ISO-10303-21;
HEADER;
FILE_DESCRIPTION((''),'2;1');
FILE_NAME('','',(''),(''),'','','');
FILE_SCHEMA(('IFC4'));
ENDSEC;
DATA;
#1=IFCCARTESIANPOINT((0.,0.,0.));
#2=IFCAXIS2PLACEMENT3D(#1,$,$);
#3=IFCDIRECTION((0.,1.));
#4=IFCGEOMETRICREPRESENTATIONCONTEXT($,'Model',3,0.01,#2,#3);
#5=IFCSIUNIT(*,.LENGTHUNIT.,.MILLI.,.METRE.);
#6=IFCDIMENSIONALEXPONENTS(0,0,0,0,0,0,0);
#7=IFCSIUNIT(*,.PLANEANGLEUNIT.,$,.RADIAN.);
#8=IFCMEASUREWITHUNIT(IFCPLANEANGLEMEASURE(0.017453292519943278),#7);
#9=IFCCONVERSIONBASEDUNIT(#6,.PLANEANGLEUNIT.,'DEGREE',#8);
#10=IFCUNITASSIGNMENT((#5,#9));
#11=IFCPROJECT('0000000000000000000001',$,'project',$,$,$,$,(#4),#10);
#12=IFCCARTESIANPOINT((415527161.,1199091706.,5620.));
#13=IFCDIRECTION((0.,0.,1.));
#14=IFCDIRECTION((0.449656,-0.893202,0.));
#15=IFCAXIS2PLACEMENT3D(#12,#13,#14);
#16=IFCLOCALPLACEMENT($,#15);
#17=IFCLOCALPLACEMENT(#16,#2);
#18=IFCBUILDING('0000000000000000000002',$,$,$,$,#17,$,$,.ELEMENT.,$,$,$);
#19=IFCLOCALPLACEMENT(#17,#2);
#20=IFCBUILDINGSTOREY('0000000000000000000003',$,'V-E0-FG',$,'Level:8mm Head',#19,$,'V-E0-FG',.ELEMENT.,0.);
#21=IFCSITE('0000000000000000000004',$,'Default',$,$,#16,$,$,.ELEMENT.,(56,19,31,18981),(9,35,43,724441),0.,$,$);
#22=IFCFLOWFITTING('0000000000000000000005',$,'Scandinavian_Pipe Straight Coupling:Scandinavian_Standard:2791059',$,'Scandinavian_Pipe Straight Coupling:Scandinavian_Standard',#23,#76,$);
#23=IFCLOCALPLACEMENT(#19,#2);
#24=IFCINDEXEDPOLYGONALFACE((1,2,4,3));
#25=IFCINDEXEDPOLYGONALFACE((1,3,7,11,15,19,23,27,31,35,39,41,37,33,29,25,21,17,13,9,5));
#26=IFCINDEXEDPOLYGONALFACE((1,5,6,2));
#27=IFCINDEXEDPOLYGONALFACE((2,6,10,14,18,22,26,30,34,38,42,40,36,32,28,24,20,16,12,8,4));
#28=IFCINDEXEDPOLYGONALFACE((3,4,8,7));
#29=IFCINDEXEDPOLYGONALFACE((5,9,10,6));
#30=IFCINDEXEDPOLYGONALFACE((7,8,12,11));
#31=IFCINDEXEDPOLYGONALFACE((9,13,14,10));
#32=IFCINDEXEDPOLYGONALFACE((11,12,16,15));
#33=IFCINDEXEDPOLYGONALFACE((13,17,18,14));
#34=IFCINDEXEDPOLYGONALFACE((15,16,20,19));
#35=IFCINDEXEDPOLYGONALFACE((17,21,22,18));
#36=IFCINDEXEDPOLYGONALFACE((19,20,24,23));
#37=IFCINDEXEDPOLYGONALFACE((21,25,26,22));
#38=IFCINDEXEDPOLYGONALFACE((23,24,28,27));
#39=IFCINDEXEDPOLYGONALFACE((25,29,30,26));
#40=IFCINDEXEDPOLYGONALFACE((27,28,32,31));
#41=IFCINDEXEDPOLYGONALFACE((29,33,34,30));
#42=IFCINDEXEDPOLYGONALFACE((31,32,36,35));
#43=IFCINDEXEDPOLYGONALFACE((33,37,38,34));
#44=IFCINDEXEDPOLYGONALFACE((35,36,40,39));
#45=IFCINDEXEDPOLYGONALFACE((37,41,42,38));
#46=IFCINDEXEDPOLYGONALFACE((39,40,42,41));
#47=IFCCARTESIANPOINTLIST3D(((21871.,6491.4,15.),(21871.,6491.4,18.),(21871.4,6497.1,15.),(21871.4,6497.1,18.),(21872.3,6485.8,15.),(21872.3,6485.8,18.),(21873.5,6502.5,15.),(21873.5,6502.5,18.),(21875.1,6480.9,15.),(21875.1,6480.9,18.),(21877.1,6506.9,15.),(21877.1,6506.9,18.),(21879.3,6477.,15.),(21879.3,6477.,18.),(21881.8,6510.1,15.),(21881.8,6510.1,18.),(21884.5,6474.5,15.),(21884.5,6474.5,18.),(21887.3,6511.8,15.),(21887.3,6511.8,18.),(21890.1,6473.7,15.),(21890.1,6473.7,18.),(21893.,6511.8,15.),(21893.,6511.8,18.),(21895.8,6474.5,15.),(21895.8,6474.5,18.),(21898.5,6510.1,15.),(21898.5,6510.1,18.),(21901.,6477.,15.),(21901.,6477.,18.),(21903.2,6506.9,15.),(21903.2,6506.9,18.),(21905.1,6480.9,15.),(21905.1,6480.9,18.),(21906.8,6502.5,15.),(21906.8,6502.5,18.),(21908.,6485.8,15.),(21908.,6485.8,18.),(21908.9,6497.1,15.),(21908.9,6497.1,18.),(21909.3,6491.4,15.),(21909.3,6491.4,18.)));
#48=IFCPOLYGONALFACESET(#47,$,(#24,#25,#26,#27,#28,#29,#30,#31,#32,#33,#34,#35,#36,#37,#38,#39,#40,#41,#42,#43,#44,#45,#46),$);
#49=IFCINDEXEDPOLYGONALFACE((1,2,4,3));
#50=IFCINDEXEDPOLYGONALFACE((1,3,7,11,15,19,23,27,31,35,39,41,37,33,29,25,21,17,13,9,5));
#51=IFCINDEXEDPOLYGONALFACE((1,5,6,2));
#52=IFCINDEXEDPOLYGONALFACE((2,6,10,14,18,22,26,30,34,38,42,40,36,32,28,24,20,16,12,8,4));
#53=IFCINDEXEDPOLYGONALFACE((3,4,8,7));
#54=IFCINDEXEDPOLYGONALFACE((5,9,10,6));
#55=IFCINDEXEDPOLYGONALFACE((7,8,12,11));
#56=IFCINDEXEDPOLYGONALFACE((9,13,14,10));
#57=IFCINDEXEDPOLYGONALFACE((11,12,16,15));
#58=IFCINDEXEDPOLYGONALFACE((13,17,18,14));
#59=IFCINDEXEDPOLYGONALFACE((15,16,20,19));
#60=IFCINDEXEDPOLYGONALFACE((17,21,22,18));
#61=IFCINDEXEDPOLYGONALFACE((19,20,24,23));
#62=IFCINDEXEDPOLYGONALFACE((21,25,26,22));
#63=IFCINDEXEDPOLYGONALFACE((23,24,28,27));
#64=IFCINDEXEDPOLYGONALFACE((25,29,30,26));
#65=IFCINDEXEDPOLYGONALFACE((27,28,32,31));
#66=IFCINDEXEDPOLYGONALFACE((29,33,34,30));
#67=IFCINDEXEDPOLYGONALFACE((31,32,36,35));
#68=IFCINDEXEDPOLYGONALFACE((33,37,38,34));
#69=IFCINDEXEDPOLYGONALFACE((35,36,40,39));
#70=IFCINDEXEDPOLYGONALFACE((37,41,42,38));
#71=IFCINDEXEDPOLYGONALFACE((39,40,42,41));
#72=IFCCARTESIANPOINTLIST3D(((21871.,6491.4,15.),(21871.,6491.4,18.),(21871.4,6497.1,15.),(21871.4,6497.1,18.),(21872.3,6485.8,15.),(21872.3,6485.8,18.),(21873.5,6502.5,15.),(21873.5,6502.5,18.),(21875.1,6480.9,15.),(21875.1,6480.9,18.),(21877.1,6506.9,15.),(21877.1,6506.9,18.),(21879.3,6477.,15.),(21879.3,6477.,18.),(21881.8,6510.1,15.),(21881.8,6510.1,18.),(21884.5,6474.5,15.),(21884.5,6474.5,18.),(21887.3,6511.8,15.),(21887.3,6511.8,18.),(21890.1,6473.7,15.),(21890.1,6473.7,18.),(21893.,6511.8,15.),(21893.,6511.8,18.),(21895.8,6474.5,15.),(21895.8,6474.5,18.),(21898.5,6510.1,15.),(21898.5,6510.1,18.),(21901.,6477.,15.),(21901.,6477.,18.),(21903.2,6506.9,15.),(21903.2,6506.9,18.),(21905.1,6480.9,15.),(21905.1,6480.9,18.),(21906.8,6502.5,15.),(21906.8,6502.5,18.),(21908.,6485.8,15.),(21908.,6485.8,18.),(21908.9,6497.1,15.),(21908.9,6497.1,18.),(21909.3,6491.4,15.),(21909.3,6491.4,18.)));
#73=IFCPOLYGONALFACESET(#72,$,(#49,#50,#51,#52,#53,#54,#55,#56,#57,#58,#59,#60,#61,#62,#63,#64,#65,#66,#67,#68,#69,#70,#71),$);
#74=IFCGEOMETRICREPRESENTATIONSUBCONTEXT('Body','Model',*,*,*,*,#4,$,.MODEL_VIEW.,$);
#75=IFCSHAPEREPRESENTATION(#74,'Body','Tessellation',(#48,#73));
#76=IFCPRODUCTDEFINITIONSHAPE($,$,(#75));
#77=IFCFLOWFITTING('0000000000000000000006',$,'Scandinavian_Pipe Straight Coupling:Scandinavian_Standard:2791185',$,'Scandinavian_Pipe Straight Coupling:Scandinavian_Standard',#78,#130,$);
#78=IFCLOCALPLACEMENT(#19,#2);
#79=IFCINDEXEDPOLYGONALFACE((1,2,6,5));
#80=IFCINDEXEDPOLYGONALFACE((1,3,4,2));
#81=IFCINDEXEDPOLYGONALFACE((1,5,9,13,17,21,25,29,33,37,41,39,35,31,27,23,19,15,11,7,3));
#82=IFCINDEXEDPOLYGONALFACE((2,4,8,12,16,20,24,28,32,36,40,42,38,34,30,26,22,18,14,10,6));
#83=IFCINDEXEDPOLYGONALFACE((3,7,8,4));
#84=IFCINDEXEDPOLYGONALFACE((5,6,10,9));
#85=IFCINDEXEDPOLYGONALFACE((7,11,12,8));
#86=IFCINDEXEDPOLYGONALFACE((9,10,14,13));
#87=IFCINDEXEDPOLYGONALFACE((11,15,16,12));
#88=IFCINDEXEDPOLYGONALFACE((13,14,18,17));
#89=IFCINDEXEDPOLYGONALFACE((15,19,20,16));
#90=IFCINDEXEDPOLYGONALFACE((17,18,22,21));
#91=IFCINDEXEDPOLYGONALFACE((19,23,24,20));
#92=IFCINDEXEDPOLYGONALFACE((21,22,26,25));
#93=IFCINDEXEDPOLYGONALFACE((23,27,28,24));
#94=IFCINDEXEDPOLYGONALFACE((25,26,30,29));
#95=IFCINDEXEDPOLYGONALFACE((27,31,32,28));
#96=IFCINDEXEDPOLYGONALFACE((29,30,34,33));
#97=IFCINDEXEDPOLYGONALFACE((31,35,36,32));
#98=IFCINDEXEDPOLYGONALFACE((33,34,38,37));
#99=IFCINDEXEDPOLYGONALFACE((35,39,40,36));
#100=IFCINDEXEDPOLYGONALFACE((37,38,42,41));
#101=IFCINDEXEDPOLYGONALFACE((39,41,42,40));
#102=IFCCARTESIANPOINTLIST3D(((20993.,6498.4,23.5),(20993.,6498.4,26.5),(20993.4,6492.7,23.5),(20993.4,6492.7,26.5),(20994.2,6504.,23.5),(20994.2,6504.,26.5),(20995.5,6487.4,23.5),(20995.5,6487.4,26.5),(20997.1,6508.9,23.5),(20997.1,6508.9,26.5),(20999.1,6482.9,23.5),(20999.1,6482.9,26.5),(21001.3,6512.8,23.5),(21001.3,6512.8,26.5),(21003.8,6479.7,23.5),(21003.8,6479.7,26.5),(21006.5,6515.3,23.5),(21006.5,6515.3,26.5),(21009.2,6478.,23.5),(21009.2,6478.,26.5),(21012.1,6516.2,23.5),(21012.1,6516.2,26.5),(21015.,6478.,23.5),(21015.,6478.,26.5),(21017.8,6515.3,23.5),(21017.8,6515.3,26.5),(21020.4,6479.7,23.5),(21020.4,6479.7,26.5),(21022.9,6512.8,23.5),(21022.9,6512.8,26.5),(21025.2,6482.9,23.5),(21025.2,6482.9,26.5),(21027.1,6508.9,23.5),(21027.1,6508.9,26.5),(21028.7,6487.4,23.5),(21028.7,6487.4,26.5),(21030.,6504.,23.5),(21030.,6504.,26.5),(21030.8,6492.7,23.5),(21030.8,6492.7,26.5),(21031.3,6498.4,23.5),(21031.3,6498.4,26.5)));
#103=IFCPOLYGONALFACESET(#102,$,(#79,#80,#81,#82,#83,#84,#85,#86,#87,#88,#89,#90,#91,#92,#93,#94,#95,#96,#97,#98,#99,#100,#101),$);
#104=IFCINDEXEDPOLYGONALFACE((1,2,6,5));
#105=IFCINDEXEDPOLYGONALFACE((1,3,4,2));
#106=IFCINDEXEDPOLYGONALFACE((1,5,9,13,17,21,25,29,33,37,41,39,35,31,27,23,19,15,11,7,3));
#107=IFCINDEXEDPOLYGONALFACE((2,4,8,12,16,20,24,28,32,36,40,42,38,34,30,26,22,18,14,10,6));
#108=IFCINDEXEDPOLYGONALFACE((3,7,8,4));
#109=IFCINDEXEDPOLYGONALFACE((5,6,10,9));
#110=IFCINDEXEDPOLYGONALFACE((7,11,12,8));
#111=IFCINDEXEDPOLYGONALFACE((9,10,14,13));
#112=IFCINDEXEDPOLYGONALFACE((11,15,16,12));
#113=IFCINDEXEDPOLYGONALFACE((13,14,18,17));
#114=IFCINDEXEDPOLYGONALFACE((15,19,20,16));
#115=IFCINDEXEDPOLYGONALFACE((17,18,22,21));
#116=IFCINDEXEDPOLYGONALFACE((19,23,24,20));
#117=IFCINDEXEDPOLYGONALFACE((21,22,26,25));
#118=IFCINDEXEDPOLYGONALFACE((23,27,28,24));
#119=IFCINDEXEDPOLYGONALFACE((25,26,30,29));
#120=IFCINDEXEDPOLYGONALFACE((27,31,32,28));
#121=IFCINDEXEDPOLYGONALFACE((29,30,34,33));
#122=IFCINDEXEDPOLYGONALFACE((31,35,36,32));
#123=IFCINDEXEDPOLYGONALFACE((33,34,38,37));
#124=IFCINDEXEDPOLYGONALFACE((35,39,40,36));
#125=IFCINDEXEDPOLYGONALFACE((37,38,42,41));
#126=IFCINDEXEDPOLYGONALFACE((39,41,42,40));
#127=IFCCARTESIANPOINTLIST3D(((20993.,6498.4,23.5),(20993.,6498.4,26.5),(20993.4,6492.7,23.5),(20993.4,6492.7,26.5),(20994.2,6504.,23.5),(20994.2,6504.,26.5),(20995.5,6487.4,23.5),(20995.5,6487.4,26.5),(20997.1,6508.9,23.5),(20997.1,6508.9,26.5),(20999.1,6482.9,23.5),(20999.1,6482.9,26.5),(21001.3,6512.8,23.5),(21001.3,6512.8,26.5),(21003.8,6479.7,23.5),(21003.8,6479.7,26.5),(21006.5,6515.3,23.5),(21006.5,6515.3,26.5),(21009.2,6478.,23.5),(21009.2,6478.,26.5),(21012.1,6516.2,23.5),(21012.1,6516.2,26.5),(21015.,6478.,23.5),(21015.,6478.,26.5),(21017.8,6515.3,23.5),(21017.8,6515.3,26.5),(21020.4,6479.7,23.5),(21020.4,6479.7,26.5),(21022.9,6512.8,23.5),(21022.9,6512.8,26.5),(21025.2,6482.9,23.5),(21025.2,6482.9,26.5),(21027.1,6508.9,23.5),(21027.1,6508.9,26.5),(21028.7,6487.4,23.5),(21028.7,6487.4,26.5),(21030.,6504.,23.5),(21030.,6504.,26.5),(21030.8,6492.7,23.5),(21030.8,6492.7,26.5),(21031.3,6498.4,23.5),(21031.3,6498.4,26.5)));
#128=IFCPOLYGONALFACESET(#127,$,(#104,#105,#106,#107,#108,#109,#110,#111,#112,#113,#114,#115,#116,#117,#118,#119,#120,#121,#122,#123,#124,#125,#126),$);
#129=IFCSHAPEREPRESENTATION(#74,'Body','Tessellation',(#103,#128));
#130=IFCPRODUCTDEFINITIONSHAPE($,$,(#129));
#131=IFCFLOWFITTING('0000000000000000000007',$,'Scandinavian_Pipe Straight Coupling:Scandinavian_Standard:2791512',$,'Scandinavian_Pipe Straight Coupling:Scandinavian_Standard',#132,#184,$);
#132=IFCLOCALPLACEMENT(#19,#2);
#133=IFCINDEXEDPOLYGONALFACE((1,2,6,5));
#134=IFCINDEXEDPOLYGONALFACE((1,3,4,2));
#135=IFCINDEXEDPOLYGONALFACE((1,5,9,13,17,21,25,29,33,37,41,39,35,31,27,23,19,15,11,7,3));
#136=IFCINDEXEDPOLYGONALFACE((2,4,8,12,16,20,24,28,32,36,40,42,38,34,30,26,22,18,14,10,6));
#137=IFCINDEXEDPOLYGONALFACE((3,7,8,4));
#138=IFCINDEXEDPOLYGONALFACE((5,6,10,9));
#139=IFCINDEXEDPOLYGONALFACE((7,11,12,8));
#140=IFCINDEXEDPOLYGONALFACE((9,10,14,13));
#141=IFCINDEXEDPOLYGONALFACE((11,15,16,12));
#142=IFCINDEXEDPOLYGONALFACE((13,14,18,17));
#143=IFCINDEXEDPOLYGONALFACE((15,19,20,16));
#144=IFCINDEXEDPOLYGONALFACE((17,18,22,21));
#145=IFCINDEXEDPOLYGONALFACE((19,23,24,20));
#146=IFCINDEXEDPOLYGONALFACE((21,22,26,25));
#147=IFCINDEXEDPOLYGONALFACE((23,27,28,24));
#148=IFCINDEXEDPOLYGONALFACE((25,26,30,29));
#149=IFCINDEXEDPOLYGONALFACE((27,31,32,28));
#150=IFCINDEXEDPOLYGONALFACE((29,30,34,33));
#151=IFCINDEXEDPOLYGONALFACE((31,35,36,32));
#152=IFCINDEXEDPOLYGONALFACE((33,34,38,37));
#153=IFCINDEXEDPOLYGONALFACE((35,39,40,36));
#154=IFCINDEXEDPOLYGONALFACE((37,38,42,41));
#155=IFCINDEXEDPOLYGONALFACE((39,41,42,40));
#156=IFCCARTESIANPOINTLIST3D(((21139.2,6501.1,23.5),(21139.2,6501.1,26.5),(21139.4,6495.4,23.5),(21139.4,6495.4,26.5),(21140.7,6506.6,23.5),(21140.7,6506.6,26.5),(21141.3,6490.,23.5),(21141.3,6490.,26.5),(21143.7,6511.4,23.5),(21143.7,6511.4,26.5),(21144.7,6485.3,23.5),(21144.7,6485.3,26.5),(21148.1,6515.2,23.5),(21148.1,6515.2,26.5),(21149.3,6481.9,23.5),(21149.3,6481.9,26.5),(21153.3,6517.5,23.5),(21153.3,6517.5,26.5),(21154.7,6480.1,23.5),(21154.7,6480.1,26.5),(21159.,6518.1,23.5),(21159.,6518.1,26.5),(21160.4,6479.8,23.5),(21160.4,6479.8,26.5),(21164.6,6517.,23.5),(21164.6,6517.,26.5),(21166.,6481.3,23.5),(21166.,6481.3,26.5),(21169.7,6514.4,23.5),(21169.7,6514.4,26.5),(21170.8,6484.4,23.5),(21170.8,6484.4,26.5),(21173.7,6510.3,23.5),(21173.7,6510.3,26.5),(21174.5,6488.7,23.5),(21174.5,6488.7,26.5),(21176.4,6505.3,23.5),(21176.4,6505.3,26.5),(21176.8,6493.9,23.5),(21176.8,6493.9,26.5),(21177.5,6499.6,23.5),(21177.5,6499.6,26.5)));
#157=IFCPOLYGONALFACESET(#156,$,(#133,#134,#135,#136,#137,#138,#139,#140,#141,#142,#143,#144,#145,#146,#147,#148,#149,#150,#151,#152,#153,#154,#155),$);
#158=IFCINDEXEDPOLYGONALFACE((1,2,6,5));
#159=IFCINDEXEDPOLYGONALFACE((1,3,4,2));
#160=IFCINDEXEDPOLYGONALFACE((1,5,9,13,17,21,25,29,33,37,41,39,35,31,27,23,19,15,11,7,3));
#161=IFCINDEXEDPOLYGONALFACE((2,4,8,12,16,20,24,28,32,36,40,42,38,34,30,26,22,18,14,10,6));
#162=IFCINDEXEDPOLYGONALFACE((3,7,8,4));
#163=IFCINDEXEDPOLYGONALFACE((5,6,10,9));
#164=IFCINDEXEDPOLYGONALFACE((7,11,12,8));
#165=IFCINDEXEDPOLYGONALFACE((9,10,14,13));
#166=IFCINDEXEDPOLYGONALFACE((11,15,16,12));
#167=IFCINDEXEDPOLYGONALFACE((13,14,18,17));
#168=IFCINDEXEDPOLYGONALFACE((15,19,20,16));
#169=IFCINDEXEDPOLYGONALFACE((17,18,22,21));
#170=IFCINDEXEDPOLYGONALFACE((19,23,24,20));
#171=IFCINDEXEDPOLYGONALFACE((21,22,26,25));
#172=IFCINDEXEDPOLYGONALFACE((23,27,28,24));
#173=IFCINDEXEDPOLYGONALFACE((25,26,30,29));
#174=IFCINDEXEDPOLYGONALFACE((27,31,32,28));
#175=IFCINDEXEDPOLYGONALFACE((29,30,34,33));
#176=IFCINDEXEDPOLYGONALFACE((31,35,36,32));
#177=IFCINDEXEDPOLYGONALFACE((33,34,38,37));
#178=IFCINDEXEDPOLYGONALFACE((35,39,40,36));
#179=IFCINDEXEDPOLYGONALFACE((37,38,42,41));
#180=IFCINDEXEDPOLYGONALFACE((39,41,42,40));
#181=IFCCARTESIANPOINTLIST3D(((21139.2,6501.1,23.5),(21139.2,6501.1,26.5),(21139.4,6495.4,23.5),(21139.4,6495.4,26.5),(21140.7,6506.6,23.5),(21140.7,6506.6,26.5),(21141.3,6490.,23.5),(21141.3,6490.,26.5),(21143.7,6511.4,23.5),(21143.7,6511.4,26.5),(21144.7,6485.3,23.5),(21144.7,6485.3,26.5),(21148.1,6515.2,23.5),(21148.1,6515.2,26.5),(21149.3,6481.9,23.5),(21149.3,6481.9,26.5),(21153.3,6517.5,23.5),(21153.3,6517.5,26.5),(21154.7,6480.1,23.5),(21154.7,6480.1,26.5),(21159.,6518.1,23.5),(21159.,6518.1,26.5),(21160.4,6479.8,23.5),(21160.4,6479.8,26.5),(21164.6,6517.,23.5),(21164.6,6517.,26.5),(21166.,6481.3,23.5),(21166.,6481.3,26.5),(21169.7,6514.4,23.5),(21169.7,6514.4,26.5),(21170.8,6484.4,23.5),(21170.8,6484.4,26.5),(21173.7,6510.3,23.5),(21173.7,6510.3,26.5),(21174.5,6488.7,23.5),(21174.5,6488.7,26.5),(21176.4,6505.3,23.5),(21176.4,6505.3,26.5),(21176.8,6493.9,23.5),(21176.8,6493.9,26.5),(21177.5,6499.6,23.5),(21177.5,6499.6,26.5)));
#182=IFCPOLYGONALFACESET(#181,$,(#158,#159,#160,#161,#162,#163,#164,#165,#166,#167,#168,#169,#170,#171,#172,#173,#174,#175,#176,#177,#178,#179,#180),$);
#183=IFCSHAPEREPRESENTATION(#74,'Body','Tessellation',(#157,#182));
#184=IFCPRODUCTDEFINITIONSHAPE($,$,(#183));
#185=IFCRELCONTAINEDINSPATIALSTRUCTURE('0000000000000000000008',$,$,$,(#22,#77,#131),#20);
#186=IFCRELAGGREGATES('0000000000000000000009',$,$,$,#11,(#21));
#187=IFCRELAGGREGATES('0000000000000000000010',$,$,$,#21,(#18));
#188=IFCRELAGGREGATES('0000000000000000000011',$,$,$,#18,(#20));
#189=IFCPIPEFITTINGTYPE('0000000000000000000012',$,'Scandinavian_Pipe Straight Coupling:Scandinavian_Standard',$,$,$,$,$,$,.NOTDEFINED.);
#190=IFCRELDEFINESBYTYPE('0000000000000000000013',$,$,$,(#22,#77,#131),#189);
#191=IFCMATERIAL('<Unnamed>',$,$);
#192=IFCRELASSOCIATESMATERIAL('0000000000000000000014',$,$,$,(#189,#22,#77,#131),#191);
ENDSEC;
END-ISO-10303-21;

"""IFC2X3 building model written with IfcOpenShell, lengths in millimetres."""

from ifc_helpers import new_model, entity, si_unit, converted_unit, direction, frame, frame_2d, origin, place, context, subcontext, project, spatial, circle, extrude, source, transform, mapped, material, type_object, type_shapes, element, save


model = new_model("IFC2X3")

# Units and contexts
model_context = context("Model", 3, precision=0.01, world=origin(), true_north=direction((0.0, 1.0)))
body_context = subcontext(model_context, "Body", "Model", "MODEL_VIEW")
ifc_project = project(units=[si_unit("LENGTHUNIT", "METRE", prefix="MILLI"), converted_unit("PLANEANGLEUNIT", "DEGREE", entity("IfcPlaneAngleMeasure", 0.017453292519943278), si_unit("PLANEANGLEUNIT", "RADIAN"), dimensions=[0, 0, 0, 0, 0, 0, 0])], contexts=[model_context])

# Site, building, storey
site_placement = place(None, frame((415527161.0, 1199091706.0, 5620.0), z_axis=(0.0, 0.0, 1.0), x_axis=(0.449656, -0.893202, 0.0)))
site = spatial("IfcSite", under=ifc_project, at=site_placement, Name="Default", CompositionType="ELEMENT", RefLatitude=(56, 19, 31, 18981), RefLongitude=(9, 35, 43, 724441), RefElevation=0.0)
building_placement = place(site_placement, origin())
building = spatial("IfcBuilding", under=site, at=building_placement, CompositionType="ELEMENT")
storey_placement = place(building_placement, origin())
storey = spatial("IfcBuildingStorey", under=building, at=storey_placement, Name="V-E0-FG", ObjectType="Level:8mm Head", LongName="V-E0-FG", CompositionType="ELEMENT", Elevation=0.0)

# Shared definitions
ifc_material = material(Name="<Unnamed>")

# Flow fittings
pipe_fitting_type = type_object("IfcPipeFittingType", Name="Scandinavian_Pipe Straight Coupling:Scandinavian_Standard", PredefinedType="NOTDEFINED", material=ifc_material)
shared_shape_1 = source(origin(), body_context, "Body", "SweptSolid", [
    extrude(circle(Radius=19.2, at=frame_2d((0.0, 0.0), x_axis=(1.0, 0.0))), frame((-1.5, 0.0, 0.0), z_axis=(1.0, 0.0, 0.0), x_axis=(0.0, 1.0, 0.0)), (0.0, 0.0, 1.0), 3.0),
    extrude(circle(Radius=19.2, at=frame_2d((0.0, 0.0), x_axis=(1.0, 0.0))), frame((-1.5, 0.0, 0.0), z_axis=(1.0, 0.0, 0.0), x_axis=(0.0, 1.0, 0.0)), (0.0, 0.0, 1.0), 3.0),
])
type_shapes(pipe_fitting_type, [shared_shape_1])
for number, where, z_axis, x_axis, name in (
    (1, (21890.1, 6492.9, 16.5), (1.0, 0.0, 0.0), (0.0, -0.000012, 1.0), "Scandinavian_Pipe Straight Coupling:Scandinavian_Standard:2791059"),
    (2, (21012.1, 6497.0, 25.0), (-1.0, 0.0, 0.0), (0.0, 0.0, 1.0), "Scandinavian_Pipe Straight Coupling:Scandinavian_Standard:2791185"),
    (3, (21158.3, 6498.9, 25.0), (-0.999292, 0.037632, 0.0), (0.0, 0.0, 1.0), "Scandinavian_Pipe Straight Coupling:Scandinavian_Standard:2791512"),
):
    element("IfcFlowFitting", number, at=place(storey_placement, frame(where, z_axis=z_axis, x_axis=x_axis)), inside=storey, type_object=pipe_fitting_type, material=ifc_material, Name=name, ObjectType="Scandinavian_Pipe Straight Coupling:Scandinavian_Standard", context=body_context, shape_type="MappedRepresentation", body=[
        mapped(shared_shape_1, transform((0.0, 0.0, 0.0), scale=1.0)),
    ])

save(model, "model.ifc")
